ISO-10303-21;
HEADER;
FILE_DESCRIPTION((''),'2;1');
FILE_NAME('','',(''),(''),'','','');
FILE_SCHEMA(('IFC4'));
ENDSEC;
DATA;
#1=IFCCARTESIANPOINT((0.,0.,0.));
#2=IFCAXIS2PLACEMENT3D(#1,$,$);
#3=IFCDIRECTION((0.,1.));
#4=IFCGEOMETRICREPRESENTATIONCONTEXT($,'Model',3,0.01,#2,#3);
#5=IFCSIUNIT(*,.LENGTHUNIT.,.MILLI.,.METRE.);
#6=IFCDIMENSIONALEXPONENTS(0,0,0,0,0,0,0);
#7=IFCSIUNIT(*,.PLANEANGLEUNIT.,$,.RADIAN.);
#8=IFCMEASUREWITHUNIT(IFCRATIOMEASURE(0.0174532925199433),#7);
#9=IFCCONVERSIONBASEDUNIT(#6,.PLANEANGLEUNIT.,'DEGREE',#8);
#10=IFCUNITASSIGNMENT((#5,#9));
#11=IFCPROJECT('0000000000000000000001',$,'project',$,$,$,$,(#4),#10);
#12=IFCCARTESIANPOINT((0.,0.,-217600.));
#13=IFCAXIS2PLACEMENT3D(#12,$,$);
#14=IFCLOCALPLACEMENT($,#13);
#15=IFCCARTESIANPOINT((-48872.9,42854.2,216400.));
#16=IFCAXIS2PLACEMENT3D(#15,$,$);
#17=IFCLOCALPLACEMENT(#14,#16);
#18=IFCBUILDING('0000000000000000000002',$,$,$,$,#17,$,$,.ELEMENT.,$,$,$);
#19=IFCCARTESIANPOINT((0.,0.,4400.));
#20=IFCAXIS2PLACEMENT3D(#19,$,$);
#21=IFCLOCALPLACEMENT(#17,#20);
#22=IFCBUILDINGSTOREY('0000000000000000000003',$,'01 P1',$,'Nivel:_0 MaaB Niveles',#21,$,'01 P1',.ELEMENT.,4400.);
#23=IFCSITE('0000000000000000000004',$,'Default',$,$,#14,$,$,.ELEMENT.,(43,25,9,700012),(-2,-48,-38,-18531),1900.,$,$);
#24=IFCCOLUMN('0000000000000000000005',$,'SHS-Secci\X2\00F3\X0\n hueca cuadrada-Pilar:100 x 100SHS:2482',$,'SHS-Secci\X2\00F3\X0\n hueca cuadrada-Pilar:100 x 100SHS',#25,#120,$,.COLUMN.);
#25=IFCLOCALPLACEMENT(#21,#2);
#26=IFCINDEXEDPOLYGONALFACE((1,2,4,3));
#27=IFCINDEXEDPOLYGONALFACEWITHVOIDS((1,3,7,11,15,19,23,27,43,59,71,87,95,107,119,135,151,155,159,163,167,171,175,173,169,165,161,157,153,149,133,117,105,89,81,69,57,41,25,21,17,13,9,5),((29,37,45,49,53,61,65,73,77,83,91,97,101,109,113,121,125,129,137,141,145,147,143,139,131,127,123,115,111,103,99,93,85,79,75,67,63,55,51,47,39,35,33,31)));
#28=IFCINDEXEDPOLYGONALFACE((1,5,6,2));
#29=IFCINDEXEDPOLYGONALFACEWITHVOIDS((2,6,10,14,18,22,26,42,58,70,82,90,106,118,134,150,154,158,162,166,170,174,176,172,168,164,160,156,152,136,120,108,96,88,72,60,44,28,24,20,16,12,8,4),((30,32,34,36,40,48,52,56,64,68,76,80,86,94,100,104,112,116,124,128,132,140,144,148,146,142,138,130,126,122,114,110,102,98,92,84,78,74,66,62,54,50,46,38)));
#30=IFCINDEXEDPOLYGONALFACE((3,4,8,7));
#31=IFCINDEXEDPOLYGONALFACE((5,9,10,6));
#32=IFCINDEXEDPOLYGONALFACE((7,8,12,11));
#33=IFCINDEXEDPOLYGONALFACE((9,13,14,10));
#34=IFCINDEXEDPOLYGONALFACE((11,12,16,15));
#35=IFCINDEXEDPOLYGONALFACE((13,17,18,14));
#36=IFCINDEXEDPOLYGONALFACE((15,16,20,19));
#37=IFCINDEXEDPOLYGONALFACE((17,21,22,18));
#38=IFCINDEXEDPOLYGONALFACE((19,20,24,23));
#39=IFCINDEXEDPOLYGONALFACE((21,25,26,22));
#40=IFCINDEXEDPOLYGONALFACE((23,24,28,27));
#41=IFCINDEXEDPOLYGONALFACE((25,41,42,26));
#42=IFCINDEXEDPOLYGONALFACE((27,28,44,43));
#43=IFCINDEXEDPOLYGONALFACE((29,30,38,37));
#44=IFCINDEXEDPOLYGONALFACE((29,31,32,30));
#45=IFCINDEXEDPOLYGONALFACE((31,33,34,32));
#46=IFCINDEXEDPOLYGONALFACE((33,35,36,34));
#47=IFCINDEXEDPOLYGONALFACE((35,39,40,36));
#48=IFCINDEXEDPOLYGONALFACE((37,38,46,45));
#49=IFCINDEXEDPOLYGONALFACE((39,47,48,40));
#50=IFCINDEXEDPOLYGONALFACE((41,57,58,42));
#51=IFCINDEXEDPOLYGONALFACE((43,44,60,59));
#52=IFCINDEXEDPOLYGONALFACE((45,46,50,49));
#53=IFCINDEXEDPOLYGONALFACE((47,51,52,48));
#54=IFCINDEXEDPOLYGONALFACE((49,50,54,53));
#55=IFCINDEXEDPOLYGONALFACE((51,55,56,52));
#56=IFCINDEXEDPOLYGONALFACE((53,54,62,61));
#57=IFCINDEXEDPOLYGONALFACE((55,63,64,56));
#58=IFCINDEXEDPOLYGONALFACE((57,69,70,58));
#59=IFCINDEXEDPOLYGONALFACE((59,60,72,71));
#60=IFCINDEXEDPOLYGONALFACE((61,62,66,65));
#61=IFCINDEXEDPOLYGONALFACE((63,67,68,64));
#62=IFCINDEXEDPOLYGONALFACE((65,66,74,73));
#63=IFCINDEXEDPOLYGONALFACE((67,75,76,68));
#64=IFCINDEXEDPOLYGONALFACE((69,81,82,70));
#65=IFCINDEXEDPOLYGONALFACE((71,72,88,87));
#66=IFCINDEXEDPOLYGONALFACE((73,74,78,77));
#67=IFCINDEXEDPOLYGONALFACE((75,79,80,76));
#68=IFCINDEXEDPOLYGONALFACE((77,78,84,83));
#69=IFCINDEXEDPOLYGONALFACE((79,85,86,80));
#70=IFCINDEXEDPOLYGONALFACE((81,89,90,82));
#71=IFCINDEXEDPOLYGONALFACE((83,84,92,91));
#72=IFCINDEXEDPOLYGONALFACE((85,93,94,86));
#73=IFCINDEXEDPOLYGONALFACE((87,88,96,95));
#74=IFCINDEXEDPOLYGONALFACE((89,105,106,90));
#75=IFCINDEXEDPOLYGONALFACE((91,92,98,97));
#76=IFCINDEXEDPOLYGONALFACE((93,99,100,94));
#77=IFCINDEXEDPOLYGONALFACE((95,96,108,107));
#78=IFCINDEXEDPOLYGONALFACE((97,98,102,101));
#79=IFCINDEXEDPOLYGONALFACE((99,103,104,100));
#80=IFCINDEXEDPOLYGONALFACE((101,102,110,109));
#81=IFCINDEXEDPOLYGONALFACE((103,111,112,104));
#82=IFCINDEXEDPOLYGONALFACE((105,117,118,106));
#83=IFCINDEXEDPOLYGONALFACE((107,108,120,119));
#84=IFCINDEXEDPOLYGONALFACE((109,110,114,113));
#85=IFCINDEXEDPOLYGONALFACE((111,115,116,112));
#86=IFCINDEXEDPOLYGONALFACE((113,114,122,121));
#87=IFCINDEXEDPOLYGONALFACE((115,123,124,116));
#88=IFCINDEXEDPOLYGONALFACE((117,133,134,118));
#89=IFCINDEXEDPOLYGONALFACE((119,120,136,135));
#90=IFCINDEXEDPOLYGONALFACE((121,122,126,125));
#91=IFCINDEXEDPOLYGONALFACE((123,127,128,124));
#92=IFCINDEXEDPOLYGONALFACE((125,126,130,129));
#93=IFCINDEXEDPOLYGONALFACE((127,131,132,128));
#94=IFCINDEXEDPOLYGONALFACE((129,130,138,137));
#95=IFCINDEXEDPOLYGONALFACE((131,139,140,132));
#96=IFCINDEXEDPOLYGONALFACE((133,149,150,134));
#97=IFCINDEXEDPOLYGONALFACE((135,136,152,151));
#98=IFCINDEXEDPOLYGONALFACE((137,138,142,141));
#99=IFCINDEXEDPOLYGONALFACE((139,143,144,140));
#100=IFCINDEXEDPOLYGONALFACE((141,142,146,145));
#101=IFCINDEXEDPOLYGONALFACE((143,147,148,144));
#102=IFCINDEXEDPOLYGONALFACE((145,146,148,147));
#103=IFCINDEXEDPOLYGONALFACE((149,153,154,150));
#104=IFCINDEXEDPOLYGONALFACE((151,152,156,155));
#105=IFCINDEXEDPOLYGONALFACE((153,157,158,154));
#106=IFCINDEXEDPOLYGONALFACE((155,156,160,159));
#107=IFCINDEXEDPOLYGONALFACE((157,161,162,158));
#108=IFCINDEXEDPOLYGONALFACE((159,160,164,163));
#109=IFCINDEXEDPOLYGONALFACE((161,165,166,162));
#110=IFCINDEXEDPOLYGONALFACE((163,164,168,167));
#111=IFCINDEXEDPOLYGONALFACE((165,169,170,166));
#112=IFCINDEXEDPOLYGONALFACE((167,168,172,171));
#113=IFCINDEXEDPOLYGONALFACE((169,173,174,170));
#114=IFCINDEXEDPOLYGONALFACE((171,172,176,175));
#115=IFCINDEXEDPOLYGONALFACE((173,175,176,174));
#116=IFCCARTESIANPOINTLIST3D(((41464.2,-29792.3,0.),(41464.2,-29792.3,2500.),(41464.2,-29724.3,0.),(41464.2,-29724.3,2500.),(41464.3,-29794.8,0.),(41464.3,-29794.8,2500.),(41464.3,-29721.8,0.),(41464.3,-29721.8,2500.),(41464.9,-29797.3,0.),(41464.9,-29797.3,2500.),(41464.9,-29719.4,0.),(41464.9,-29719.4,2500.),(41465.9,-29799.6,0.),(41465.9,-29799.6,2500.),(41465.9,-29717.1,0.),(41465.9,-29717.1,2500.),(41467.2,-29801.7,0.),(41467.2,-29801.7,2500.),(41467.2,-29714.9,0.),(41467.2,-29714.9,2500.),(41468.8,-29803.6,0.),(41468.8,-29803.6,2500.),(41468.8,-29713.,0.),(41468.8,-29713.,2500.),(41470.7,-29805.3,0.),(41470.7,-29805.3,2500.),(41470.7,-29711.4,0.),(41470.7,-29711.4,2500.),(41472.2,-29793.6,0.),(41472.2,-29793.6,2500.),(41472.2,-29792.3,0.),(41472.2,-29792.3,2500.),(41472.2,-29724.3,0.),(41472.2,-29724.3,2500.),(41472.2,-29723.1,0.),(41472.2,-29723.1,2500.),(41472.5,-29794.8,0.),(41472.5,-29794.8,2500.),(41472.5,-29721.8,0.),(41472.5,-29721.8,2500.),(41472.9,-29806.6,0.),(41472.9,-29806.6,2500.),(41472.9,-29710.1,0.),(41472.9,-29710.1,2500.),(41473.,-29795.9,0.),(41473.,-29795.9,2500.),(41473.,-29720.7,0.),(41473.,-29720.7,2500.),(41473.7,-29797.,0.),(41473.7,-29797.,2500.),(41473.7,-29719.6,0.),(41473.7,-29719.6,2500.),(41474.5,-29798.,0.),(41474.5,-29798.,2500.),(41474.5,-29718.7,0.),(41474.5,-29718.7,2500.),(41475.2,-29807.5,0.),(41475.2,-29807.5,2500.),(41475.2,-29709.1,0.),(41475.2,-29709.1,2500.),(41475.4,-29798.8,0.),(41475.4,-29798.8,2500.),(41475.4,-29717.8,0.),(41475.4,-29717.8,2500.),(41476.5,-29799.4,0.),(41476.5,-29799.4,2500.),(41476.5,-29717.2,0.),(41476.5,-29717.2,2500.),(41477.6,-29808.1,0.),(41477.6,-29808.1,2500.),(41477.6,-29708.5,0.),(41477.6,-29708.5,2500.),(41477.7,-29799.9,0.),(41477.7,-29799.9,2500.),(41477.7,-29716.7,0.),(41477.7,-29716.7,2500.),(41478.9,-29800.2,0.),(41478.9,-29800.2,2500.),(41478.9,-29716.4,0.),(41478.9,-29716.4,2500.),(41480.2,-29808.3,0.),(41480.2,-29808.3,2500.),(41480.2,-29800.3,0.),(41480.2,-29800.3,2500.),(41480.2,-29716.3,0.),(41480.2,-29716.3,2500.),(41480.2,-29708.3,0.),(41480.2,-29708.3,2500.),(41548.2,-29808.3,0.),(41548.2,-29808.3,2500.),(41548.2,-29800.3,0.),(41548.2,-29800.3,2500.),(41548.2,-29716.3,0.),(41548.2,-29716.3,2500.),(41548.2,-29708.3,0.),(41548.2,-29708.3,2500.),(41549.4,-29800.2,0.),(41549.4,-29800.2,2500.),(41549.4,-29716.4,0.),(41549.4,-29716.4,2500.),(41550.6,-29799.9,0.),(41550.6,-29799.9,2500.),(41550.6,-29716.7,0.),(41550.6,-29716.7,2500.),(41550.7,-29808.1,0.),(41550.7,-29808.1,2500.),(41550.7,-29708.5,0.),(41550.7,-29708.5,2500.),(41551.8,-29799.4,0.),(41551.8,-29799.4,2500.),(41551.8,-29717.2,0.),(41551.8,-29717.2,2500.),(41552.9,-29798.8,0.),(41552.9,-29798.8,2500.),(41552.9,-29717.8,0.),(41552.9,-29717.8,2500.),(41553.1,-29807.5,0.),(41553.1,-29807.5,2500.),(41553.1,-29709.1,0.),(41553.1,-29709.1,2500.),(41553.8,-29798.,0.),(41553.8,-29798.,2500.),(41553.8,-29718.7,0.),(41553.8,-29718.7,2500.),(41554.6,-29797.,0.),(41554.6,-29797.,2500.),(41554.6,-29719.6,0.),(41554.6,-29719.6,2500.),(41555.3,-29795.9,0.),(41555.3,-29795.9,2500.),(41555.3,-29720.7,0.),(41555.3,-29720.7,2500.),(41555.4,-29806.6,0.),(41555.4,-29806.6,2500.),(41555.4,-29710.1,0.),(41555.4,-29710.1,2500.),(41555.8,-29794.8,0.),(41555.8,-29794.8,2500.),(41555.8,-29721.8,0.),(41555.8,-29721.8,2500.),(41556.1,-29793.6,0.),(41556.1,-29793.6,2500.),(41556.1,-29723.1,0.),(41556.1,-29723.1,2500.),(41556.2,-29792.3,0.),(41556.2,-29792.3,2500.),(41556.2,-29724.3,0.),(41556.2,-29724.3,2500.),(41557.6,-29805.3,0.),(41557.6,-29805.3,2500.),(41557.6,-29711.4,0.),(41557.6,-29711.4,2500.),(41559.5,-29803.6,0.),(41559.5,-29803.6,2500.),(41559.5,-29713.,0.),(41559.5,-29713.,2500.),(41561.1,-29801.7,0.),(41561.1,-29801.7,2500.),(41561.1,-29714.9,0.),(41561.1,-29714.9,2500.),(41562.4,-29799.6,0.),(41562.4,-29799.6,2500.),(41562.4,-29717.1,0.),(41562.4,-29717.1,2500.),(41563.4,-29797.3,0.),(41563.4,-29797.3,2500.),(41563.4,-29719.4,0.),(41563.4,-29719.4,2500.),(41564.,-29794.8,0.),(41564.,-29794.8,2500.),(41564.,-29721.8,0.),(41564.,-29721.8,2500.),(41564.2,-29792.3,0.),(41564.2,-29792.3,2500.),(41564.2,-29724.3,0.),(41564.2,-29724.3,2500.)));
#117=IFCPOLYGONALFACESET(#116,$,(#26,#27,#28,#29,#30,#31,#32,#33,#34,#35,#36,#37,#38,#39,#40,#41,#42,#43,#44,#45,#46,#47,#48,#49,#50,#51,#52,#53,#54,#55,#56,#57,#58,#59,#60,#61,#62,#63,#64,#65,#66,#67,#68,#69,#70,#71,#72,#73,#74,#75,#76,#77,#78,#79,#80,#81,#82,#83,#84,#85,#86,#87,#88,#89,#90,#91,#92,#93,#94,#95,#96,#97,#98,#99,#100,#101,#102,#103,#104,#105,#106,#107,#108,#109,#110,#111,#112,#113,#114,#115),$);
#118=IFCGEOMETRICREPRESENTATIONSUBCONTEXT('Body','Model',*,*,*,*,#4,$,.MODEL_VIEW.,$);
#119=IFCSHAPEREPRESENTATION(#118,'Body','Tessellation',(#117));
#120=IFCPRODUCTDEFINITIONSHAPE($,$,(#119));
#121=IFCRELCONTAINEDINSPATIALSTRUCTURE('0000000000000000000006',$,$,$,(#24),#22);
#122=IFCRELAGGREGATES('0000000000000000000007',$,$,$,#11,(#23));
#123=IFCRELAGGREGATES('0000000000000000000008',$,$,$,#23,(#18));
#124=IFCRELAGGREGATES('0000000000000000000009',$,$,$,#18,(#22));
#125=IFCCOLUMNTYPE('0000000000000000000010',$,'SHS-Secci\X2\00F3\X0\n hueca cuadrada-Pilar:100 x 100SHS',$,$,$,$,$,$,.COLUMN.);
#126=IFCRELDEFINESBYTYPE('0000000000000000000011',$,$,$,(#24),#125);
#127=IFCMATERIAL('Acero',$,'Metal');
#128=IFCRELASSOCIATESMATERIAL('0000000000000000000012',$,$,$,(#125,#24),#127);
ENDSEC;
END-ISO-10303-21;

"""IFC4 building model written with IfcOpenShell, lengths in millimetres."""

from ifc_helpers import new_model, entity, si_unit, converted_unit, direction, frame, origin, place, context, subcontext, project, spatial, indexed_curve, outline, extrude, source, transform, mapped, material, type_object, type_shapes, element, save


model = new_model("IFC4")

# Units and contexts
model_context = context("Model", 3, precision=0.01, world=origin(), true_north=direction((0.0, 1.0)))
body_context = subcontext(model_context, "Body", "Model", "MODEL_VIEW")
ifc_project = project(units=[si_unit("LENGTHUNIT", "METRE", prefix="MILLI"), converted_unit("PLANEANGLEUNIT", "DEGREE", entity("IfcRatioMeasure", 0.0174532925199433), si_unit("PLANEANGLEUNIT", "RADIAN"), dimensions=[0, 0, 0, 0, 0, 0, 0])], contexts=[model_context])

# Site, building, storey
site_placement = place(None, frame((0.0, 0.0, -217600.0)))
site = spatial("IfcSite", under=ifc_project, at=site_placement, Name="Default", CompositionType="ELEMENT", RefLatitude=(43, 25, 9, 700012), RefLongitude=(-2, -48, -38, -18531), RefElevation=1900.0)
building_placement = place(site_placement, frame((-48872.9, 42854.2, 216400.0)))
building = spatial("IfcBuilding", under=site, at=building_placement, CompositionType="ELEMENT")
storey_placement = place(building_placement, frame((0.0, 0.0, 4400.0)))
storey = spatial("IfcBuildingStorey", under=building, at=storey_placement, Name="01 P1", ObjectType="Nivel:_0 MaaB Niveles", LongName="01 P1", CompositionType="ELEMENT", Elevation=4400.0)

# Column
ifc_material_1 = material(Name="Acero", Category="Metal")
column_type_1 = type_object("IfcColumnType", Name="SHS-Sección hueca cuadrada-Pilar:100 x 100SHS", PredefinedType="COLUMN", material=ifc_material_1)
shared_shape_1 = source(origin(), body_context, "Body", "SweptSolid", [
    extrude(outline(indexed_curve([(-34.0, -50.0), (34.0, -50.0), (36.5, -49.8), (38.9, -49.2), (41.3, -48.3), (43.4, -46.9), (45.3, -45.3), (46.9, -43.4), (48.3, -41.3), (49.2, -38.9), (49.8, -36.5), (50.0, -34.0), (50.0, 34.0), (49.8, 36.5), (49.2, 38.9), (48.3, 41.3), (46.9, 43.4), (45.3, 45.3), (43.4, 46.9), (41.3, 48.3), (38.9, 49.2), (36.5, 49.8), (34.0, 50.0), (-34.0, 50.0), (-36.5, 49.8), (-38.9, 49.2), (-41.3, 48.3), (-43.4, 46.9), (-45.3, 45.3), (-46.9, 43.4), (-48.3, 41.3), (-49.2, 38.9), (-49.8, 36.5), (-50.0, 34.0), (-50.0, -34.0), (-49.8, -36.5), (-49.2, -38.9), (-48.3, -41.3), (-46.9, -43.4), (-45.3, -45.3), (-43.4, -46.9), (-41.3, -48.3), (-38.9, -49.2), (-36.5, -49.8), (-34.0, -50.0)], self_intersect=False), holes=[indexed_curve([(-42.0, 34.0), (-41.9, 35.3), (-41.6, 36.5), (-41.1, 37.6), (-40.5, 38.7), (-39.7, 39.7), (-38.7, 40.5), (-37.6, 41.1), (-36.5, 41.6), (-35.3, 41.9), (-34.0, 42.0), (34.0, 42.0), (35.3, 41.9), (36.5, 41.6), (37.6, 41.1), (38.7, 40.5), (39.7, 39.7), (40.5, 38.7), (41.1, 37.6), (41.6, 36.5), (41.9, 35.3), (42.0, 34.0), (42.0, -34.0), (41.9, -35.3), (41.6, -36.5), (41.1, -37.6), (40.5, -38.7), (39.7, -39.7), (38.7, -40.5), (37.6, -41.1), (36.5, -41.6), (35.3, -41.9), (34.0, -42.0), (-34.0, -42.0), (-35.3, -41.9), (-36.5, -41.6), (-37.6, -41.1), (-38.7, -40.5), (-39.7, -39.7), (-40.5, -38.7), (-41.1, -37.6), (-41.6, -36.5), (-41.9, -35.3), (-42.0, -34.0), (-42.0, 34.0)], self_intersect=False)]), frame((0.0, 0.0, 4400.0), z_axis=(0.0, 0.0, 1.0), x_axis=(0.0, 1.0, 0.0)), (0.0, 0.0, 1.0), 2500.0),
])
type_shapes(column_type_1, [shared_shape_1])
column_1_placement = place(storey_placement, frame((41514.2, -29758.3, -4400.0), z_axis=(0.0, 0.0, 1.0), x_axis=(0.0, -1.0, 0.0)))
element("IfcColumn", 1, at=column_1_placement, inside=storey, type_object=column_type_1, material=ifc_material_1, Name="SHS-Sección hueca cuadrada-Pilar:100 x 100SHS:2482", ObjectType="SHS-Sección hueca cuadrada-Pilar:100 x 100SHS", PredefinedType="COLUMN", context=body_context, shape_type="MappedRepresentation", body=[
    mapped(shared_shape_1, transform((0.0, 0.0, 0.0), scale=1.0)),
])

save(model, "model.ifc")
